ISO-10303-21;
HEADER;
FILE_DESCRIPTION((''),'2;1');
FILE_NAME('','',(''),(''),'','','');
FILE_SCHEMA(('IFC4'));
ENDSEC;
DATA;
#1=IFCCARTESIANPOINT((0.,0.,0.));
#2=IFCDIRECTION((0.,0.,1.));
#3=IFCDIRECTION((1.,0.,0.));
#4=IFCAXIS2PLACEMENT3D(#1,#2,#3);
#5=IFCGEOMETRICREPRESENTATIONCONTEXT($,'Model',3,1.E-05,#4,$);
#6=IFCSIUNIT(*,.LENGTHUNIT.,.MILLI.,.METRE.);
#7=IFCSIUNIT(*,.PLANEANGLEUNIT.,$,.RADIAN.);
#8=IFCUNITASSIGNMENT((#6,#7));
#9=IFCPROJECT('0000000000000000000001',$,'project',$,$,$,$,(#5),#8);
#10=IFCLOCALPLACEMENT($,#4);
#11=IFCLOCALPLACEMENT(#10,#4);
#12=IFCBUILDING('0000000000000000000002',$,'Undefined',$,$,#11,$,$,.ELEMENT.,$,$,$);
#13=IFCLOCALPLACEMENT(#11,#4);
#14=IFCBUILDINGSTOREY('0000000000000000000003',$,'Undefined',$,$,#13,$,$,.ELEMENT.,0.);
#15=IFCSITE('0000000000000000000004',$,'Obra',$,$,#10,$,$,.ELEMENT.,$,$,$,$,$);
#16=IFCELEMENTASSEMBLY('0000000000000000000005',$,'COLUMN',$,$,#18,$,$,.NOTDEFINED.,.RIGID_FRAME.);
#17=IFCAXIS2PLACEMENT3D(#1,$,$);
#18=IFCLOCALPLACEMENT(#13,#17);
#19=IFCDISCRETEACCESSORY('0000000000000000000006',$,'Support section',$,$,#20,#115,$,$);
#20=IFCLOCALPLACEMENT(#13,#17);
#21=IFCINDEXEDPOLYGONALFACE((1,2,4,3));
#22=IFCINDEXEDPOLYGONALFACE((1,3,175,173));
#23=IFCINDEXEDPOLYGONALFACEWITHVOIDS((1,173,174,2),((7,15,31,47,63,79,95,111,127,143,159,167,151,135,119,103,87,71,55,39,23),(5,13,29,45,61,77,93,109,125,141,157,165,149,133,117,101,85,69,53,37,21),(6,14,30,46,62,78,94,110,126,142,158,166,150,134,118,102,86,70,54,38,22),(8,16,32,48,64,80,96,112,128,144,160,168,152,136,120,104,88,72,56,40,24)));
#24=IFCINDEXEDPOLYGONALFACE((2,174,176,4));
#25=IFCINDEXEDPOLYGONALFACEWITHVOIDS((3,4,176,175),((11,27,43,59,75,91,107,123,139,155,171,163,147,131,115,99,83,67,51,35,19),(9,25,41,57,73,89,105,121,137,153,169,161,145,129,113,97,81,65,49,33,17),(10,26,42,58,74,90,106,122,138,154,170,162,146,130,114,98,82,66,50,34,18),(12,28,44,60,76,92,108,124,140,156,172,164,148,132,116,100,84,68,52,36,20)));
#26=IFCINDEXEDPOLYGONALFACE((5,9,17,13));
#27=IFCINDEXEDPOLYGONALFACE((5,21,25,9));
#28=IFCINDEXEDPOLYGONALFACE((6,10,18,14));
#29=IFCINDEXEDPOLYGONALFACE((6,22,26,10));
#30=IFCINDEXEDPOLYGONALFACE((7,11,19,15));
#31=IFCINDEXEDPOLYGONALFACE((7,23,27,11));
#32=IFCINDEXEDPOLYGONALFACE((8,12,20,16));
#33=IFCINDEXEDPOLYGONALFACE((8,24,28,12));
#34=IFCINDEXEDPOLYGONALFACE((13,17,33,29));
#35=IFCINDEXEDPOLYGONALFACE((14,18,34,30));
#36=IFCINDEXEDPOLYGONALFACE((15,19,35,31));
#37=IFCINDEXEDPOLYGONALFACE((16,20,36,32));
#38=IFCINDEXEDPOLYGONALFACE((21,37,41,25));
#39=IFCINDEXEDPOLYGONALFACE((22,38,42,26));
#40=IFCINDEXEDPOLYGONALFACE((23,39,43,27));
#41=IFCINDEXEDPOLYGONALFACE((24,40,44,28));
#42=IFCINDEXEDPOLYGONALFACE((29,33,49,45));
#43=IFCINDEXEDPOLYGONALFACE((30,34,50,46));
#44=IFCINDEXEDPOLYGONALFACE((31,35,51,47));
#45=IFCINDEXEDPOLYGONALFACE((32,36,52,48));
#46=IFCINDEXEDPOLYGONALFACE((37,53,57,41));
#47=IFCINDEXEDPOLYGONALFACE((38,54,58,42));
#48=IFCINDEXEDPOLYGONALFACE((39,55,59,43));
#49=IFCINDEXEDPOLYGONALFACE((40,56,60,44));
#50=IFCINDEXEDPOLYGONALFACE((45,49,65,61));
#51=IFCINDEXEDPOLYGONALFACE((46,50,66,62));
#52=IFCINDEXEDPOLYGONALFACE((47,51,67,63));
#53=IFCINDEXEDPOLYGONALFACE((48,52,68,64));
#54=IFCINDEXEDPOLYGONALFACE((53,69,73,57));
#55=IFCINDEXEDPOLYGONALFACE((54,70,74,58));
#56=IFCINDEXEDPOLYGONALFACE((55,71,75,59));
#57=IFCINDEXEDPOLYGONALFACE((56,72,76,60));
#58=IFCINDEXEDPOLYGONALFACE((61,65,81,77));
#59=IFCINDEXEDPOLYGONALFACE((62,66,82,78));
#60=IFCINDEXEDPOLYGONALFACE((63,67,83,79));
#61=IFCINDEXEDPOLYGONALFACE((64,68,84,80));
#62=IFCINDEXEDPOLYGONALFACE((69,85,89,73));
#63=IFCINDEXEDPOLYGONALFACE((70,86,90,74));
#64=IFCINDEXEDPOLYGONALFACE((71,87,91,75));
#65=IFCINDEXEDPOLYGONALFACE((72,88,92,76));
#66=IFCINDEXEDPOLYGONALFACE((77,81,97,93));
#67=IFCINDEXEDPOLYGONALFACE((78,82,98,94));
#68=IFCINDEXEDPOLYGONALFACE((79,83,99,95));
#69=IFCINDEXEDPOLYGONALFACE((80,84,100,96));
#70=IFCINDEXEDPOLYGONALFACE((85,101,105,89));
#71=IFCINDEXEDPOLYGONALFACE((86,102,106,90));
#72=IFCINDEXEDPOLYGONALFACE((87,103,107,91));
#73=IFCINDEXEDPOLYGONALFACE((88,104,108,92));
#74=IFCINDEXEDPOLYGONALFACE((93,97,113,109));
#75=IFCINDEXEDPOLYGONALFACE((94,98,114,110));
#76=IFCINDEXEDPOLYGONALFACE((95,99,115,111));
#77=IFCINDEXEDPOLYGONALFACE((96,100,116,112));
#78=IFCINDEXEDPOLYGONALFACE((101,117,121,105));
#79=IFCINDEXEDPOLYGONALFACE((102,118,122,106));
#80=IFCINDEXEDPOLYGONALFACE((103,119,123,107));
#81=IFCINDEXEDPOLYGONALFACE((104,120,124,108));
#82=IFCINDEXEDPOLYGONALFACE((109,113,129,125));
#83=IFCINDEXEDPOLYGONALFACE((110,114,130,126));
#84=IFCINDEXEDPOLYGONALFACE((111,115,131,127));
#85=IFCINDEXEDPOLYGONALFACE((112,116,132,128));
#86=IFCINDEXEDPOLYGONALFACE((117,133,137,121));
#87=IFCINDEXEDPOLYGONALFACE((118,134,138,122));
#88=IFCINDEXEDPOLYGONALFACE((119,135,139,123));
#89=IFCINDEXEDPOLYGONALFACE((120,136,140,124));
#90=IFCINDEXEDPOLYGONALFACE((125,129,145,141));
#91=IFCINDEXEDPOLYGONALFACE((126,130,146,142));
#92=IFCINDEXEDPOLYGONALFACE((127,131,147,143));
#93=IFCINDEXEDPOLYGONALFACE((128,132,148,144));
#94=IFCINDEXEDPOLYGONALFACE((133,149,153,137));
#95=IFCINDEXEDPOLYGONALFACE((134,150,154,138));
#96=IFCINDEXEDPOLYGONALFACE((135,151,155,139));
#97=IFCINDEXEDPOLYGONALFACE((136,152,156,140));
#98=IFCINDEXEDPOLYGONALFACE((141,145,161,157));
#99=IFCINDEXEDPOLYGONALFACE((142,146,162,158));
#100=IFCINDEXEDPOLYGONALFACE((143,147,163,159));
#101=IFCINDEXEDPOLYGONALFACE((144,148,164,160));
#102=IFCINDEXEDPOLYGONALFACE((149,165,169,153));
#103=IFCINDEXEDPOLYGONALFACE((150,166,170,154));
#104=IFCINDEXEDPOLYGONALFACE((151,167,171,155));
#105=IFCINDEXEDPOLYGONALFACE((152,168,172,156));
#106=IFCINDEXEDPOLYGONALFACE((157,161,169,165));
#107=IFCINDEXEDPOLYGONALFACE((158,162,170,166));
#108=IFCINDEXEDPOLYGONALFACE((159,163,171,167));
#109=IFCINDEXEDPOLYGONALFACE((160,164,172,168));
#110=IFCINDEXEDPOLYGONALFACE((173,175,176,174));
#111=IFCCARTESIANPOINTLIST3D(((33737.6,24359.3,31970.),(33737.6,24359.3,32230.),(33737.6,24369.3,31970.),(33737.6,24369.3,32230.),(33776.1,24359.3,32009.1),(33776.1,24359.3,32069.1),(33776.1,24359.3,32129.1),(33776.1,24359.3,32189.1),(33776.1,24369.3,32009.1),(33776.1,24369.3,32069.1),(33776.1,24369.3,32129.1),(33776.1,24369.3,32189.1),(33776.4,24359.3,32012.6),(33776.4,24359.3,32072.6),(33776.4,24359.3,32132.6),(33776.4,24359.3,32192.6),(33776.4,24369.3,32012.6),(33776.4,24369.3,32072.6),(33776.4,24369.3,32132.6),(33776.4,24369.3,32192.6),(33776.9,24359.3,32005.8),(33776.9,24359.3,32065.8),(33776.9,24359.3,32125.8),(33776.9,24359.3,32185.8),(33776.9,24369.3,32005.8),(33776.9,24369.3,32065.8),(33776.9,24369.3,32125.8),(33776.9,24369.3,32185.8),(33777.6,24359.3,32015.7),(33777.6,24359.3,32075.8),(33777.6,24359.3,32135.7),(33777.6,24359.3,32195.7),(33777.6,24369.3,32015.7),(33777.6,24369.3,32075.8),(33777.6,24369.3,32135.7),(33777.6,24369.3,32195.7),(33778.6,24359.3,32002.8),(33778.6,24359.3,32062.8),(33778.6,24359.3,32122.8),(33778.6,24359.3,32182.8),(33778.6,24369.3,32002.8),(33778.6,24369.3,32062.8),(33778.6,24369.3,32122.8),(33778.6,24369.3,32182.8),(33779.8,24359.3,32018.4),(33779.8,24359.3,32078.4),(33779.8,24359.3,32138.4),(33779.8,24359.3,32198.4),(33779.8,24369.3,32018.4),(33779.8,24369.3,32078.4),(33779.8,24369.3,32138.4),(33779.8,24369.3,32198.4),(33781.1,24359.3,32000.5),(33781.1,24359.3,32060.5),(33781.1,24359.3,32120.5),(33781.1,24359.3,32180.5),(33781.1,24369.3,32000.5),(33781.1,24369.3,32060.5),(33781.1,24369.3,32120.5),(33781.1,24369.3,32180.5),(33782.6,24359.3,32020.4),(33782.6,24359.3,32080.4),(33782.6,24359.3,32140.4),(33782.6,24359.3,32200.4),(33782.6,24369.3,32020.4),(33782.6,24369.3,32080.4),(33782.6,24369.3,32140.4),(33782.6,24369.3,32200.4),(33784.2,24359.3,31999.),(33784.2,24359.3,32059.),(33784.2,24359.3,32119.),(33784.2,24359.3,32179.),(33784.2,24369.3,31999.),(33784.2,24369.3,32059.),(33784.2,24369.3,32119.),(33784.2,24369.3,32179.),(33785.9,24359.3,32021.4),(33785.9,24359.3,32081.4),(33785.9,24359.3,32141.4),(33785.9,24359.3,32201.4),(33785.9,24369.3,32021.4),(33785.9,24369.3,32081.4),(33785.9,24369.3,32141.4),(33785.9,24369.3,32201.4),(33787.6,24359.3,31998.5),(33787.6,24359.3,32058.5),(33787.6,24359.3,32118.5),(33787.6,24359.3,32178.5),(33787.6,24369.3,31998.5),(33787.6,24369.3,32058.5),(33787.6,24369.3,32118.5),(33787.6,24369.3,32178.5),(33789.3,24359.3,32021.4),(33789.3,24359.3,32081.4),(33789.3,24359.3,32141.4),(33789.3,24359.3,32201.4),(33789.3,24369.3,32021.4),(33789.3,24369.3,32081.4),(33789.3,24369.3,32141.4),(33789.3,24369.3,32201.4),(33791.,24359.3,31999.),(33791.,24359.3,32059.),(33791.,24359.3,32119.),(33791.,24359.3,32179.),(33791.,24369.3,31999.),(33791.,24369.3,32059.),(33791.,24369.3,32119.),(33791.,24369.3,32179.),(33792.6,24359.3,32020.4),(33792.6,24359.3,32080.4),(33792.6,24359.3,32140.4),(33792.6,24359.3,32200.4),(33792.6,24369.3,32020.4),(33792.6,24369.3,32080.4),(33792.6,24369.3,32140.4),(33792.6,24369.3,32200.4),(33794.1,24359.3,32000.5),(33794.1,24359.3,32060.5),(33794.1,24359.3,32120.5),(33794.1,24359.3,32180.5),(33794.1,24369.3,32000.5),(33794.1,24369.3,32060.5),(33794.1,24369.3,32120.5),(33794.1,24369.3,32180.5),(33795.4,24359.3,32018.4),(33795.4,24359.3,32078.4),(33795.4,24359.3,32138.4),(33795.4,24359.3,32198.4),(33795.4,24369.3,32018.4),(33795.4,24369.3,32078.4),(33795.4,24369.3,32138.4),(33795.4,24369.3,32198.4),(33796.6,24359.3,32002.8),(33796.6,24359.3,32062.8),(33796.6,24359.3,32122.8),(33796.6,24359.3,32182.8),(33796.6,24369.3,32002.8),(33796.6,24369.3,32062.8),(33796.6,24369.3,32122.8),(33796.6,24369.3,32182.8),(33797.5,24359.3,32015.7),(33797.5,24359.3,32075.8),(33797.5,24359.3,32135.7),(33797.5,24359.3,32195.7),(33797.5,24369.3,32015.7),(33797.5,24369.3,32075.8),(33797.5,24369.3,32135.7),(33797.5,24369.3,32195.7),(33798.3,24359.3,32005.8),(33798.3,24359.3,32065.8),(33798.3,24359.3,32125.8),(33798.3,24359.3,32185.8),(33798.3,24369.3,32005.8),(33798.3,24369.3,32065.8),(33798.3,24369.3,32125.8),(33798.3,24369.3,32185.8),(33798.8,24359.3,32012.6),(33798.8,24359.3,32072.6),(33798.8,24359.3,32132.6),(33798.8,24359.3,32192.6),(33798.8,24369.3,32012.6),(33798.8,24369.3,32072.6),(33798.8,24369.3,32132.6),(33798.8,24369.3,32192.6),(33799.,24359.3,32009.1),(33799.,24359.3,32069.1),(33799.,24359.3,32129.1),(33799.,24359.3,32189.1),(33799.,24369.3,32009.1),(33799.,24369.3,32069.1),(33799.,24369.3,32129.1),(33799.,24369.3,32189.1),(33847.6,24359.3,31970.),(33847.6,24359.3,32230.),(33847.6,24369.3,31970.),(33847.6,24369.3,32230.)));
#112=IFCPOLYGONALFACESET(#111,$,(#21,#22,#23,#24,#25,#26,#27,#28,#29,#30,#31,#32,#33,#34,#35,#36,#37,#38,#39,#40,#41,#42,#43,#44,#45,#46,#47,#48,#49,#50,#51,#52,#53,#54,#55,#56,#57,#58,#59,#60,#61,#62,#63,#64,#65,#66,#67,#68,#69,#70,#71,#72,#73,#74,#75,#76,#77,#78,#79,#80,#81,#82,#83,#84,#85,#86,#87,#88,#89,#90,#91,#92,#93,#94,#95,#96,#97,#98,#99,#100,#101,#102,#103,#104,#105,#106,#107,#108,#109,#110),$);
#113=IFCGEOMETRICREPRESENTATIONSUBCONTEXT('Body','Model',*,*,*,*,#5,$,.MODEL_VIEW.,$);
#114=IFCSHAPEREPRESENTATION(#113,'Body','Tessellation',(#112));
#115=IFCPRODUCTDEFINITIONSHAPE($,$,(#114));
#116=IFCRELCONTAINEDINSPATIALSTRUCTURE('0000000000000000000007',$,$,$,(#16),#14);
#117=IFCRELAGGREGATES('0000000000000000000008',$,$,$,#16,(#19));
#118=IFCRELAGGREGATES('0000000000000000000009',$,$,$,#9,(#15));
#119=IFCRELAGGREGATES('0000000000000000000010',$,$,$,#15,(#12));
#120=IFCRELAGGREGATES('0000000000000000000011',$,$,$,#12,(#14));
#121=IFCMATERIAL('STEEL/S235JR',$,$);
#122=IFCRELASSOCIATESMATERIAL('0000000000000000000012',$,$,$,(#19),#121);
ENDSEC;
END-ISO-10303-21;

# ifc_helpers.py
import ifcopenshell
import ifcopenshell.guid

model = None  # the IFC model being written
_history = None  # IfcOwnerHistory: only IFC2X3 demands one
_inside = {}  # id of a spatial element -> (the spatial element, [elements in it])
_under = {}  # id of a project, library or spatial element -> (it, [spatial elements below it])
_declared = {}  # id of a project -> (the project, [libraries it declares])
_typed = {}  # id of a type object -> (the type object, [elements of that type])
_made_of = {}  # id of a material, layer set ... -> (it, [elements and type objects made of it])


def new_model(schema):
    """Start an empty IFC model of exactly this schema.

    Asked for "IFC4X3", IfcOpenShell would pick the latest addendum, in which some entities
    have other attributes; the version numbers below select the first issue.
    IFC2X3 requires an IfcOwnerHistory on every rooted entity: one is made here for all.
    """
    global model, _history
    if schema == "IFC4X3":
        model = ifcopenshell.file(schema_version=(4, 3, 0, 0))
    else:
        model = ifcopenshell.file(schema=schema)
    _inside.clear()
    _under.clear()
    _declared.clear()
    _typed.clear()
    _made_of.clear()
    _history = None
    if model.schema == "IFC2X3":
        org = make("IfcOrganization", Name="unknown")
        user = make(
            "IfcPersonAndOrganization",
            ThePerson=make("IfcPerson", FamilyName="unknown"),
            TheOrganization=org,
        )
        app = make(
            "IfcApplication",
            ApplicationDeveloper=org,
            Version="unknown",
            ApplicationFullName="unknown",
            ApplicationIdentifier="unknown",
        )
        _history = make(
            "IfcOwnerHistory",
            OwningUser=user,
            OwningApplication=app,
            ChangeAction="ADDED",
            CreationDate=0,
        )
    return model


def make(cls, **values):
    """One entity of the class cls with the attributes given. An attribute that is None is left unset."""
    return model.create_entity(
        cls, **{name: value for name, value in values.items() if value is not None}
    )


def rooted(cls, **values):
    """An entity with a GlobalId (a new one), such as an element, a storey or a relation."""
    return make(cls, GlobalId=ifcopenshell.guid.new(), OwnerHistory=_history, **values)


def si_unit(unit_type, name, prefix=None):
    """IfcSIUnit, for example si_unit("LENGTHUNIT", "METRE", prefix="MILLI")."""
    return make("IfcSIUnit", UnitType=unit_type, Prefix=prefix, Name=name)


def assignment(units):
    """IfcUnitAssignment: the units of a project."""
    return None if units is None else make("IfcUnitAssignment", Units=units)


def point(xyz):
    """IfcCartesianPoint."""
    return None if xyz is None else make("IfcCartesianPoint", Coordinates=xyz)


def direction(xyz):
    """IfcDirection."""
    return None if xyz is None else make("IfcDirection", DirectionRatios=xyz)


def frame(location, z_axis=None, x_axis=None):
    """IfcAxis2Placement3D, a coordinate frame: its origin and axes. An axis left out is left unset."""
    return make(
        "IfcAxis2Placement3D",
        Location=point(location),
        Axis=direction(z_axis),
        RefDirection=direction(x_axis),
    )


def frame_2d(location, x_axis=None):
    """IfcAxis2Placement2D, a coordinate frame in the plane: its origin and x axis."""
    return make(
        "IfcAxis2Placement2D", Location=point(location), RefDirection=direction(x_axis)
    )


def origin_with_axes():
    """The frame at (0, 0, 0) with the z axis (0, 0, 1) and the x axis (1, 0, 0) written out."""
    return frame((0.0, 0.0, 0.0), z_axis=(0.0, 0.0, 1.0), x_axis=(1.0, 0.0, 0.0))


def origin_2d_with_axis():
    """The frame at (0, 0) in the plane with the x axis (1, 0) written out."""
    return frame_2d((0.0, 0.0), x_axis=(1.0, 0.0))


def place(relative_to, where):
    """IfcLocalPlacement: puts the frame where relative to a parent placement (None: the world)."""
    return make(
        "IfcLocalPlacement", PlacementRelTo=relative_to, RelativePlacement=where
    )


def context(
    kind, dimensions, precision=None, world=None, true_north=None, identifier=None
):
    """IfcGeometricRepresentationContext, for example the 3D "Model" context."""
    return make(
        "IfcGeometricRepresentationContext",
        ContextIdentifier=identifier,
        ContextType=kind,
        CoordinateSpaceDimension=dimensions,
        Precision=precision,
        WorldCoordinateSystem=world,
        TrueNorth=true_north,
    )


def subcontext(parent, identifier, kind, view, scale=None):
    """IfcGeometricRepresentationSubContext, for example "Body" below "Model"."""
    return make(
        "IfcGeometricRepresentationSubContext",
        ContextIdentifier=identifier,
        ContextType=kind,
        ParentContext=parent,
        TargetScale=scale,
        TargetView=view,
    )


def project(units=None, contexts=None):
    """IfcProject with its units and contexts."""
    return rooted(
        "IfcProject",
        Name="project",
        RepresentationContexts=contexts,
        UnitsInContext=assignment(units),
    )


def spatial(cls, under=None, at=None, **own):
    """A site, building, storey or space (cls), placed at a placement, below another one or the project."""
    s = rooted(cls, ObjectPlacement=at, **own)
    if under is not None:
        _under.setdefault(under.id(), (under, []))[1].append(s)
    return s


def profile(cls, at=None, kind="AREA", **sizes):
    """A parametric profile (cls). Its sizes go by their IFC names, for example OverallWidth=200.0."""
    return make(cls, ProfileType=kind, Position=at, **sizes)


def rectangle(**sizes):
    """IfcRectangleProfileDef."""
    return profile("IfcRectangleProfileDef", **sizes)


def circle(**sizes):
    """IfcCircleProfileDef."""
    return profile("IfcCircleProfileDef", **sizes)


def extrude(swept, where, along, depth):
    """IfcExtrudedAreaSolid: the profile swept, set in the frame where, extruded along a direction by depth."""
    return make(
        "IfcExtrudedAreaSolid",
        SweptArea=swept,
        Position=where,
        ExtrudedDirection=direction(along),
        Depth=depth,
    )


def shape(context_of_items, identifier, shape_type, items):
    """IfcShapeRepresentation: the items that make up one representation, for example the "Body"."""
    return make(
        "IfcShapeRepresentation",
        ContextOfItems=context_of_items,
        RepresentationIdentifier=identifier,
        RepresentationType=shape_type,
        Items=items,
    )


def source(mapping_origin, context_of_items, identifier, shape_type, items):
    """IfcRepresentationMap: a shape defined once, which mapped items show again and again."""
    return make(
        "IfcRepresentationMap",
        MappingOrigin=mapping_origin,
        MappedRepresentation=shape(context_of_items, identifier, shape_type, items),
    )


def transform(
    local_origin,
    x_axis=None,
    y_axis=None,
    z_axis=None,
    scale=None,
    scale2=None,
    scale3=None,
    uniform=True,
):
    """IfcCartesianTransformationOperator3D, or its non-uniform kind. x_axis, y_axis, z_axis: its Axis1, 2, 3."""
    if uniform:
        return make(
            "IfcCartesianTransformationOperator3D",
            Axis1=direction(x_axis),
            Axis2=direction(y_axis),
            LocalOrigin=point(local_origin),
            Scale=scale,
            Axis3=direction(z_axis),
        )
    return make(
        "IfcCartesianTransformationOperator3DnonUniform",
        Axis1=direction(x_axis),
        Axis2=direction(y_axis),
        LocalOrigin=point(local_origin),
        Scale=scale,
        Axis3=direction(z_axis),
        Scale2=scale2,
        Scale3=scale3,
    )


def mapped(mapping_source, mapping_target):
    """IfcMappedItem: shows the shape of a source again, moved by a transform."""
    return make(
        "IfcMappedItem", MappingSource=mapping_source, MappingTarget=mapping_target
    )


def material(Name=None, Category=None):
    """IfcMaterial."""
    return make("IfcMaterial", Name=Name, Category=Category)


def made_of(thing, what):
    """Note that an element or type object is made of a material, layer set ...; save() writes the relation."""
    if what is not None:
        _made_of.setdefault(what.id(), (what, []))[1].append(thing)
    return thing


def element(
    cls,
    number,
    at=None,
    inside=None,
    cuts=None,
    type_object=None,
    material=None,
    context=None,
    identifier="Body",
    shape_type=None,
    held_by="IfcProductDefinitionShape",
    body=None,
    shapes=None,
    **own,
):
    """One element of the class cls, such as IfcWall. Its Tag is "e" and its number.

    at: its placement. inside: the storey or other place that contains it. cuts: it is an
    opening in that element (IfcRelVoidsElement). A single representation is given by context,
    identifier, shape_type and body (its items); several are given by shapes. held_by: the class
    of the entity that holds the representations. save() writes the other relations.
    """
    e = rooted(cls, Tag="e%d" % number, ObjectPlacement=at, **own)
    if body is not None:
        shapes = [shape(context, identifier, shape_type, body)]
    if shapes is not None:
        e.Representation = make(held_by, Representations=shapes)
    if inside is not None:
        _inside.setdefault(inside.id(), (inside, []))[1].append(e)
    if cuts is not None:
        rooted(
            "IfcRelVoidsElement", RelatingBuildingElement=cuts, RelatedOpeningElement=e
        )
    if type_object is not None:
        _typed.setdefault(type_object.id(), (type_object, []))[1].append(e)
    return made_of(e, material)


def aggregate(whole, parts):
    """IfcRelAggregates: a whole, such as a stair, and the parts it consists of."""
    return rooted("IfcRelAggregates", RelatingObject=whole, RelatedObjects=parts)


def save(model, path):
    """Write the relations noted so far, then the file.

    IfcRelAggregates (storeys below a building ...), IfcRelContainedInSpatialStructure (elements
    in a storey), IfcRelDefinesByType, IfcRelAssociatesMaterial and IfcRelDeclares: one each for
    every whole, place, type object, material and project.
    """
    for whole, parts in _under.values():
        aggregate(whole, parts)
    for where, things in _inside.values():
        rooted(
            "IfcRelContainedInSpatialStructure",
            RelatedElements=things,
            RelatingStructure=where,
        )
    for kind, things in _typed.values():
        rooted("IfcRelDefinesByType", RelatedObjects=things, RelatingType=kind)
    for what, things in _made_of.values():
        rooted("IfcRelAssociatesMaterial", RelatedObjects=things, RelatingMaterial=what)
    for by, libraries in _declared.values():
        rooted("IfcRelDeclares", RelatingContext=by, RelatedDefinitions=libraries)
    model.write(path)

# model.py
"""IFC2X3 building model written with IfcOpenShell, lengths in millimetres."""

from ifc_helpers import new_model, si_unit, frame, origin_with_axes, origin_2d_with_axis, place, context, subcontext, project, spatial, rectangle, circle, extrude, source, transform, mapped, material, element, aggregate, save


model = new_model("IFC2X3")

# Units and contexts
model_context = context("Model", 3, precision=1e-05, world=origin_with_axes())
body_context = subcontext(model_context, "Body", "Model", "MODEL_VIEW")
ifc_project = project(units=[si_unit("LENGTHUNIT", "METRE", prefix="MILLI"), si_unit("PLANEANGLEUNIT", "RADIAN")], contexts=[model_context])

# Site, building, storey
site_placement = place(None, origin_with_axes())
site = spatial("IfcSite", under=ifc_project, at=site_placement, Name="Obra", CompositionType="ELEMENT")
building_placement = place(site_placement, origin_with_axes())
building = spatial("IfcBuilding", under=site, at=building_placement, Name="Undefined", CompositionType="ELEMENT")
storey_placement = place(building_placement, origin_with_axes())
storey = spatial("IfcBuildingStorey", under=building, at=storey_placement, Name="Undefined", CompositionType="ELEMENT", Elevation=0.0)

# Element assembly
assembly_1_placement = place(storey_placement, origin_with_axes())
assembly_1 = element("IfcElementAssembly", 1, at=assembly_1_placement, inside=storey, Name="COLUMN", AssemblyPlace="NOTDEFINED", PredefinedType="RIGID_FRAME")
ifc_material_1 = material(Name="STEEL/S235JR")

# Discrete accessory, opening
shared_shape_1 = source(origin_with_axes(), body_context, "Body", "SweptSolid", [
    extrude(circle(Radius=11.5, at=origin_2d_with_axis()), frame((0.0, -14.4, 0.0), z_axis=(0.0, 1.0, 0.0), x_axis=(1.0, 0.0, 0.0)), (0.0, 0.0, 1.0), 10.2),
])
discrete_accessory_1_placement = place(assembly_1_placement, frame((33792.6, 24364.3, 31970.0), z_axis=(0.0, 0.0, 1.0), x_axis=(1.0, 0.0, 0.0)))
discrete_accessory_1 = element("IfcDiscreteAccessory", 2, at=discrete_accessory_1_placement, material=ifc_material_1, Name="Support section", context=body_context, shape_type="SweptSolid", body=[
    extrude(rectangle(XDim=10.0, YDim=110.0, at=origin_2d_with_axis()), frame((0.0, 0.0, 260.0), z_axis=(0.0, 0.0, -1.0), x_axis=(0.0, 1.0, 0.0)), (0.0, 0.0, 1.0), 260.0),
])
opening_1_placement = place(assembly_1_placement, frame((33837.6, 24355.0, 32300.0), z_axis=(-1.0, 0.0, 0.0), x_axis=(0.0, 0.0, -1.0)))
element("IfcOpeningElement", 3, at=opening_1_placement, cuts=discrete_accessory_1, ObjectType="Opening", context=body_context, shape_type="MappedRepresentation", body=[
    mapped(shared_shape_1, transform((110.0, 0.0, 50.0))),
    mapped(shared_shape_1, transform((170.0, 0.0, 50.0))),
    mapped(shared_shape_1, transform((230.0, 0.0, 50.0))),
    mapped(shared_shape_1, transform((290.0, 0.0, 50.0))),
])

aggregate(assembly_1, [discrete_accessory_1])

save(model, "model.ifc")
